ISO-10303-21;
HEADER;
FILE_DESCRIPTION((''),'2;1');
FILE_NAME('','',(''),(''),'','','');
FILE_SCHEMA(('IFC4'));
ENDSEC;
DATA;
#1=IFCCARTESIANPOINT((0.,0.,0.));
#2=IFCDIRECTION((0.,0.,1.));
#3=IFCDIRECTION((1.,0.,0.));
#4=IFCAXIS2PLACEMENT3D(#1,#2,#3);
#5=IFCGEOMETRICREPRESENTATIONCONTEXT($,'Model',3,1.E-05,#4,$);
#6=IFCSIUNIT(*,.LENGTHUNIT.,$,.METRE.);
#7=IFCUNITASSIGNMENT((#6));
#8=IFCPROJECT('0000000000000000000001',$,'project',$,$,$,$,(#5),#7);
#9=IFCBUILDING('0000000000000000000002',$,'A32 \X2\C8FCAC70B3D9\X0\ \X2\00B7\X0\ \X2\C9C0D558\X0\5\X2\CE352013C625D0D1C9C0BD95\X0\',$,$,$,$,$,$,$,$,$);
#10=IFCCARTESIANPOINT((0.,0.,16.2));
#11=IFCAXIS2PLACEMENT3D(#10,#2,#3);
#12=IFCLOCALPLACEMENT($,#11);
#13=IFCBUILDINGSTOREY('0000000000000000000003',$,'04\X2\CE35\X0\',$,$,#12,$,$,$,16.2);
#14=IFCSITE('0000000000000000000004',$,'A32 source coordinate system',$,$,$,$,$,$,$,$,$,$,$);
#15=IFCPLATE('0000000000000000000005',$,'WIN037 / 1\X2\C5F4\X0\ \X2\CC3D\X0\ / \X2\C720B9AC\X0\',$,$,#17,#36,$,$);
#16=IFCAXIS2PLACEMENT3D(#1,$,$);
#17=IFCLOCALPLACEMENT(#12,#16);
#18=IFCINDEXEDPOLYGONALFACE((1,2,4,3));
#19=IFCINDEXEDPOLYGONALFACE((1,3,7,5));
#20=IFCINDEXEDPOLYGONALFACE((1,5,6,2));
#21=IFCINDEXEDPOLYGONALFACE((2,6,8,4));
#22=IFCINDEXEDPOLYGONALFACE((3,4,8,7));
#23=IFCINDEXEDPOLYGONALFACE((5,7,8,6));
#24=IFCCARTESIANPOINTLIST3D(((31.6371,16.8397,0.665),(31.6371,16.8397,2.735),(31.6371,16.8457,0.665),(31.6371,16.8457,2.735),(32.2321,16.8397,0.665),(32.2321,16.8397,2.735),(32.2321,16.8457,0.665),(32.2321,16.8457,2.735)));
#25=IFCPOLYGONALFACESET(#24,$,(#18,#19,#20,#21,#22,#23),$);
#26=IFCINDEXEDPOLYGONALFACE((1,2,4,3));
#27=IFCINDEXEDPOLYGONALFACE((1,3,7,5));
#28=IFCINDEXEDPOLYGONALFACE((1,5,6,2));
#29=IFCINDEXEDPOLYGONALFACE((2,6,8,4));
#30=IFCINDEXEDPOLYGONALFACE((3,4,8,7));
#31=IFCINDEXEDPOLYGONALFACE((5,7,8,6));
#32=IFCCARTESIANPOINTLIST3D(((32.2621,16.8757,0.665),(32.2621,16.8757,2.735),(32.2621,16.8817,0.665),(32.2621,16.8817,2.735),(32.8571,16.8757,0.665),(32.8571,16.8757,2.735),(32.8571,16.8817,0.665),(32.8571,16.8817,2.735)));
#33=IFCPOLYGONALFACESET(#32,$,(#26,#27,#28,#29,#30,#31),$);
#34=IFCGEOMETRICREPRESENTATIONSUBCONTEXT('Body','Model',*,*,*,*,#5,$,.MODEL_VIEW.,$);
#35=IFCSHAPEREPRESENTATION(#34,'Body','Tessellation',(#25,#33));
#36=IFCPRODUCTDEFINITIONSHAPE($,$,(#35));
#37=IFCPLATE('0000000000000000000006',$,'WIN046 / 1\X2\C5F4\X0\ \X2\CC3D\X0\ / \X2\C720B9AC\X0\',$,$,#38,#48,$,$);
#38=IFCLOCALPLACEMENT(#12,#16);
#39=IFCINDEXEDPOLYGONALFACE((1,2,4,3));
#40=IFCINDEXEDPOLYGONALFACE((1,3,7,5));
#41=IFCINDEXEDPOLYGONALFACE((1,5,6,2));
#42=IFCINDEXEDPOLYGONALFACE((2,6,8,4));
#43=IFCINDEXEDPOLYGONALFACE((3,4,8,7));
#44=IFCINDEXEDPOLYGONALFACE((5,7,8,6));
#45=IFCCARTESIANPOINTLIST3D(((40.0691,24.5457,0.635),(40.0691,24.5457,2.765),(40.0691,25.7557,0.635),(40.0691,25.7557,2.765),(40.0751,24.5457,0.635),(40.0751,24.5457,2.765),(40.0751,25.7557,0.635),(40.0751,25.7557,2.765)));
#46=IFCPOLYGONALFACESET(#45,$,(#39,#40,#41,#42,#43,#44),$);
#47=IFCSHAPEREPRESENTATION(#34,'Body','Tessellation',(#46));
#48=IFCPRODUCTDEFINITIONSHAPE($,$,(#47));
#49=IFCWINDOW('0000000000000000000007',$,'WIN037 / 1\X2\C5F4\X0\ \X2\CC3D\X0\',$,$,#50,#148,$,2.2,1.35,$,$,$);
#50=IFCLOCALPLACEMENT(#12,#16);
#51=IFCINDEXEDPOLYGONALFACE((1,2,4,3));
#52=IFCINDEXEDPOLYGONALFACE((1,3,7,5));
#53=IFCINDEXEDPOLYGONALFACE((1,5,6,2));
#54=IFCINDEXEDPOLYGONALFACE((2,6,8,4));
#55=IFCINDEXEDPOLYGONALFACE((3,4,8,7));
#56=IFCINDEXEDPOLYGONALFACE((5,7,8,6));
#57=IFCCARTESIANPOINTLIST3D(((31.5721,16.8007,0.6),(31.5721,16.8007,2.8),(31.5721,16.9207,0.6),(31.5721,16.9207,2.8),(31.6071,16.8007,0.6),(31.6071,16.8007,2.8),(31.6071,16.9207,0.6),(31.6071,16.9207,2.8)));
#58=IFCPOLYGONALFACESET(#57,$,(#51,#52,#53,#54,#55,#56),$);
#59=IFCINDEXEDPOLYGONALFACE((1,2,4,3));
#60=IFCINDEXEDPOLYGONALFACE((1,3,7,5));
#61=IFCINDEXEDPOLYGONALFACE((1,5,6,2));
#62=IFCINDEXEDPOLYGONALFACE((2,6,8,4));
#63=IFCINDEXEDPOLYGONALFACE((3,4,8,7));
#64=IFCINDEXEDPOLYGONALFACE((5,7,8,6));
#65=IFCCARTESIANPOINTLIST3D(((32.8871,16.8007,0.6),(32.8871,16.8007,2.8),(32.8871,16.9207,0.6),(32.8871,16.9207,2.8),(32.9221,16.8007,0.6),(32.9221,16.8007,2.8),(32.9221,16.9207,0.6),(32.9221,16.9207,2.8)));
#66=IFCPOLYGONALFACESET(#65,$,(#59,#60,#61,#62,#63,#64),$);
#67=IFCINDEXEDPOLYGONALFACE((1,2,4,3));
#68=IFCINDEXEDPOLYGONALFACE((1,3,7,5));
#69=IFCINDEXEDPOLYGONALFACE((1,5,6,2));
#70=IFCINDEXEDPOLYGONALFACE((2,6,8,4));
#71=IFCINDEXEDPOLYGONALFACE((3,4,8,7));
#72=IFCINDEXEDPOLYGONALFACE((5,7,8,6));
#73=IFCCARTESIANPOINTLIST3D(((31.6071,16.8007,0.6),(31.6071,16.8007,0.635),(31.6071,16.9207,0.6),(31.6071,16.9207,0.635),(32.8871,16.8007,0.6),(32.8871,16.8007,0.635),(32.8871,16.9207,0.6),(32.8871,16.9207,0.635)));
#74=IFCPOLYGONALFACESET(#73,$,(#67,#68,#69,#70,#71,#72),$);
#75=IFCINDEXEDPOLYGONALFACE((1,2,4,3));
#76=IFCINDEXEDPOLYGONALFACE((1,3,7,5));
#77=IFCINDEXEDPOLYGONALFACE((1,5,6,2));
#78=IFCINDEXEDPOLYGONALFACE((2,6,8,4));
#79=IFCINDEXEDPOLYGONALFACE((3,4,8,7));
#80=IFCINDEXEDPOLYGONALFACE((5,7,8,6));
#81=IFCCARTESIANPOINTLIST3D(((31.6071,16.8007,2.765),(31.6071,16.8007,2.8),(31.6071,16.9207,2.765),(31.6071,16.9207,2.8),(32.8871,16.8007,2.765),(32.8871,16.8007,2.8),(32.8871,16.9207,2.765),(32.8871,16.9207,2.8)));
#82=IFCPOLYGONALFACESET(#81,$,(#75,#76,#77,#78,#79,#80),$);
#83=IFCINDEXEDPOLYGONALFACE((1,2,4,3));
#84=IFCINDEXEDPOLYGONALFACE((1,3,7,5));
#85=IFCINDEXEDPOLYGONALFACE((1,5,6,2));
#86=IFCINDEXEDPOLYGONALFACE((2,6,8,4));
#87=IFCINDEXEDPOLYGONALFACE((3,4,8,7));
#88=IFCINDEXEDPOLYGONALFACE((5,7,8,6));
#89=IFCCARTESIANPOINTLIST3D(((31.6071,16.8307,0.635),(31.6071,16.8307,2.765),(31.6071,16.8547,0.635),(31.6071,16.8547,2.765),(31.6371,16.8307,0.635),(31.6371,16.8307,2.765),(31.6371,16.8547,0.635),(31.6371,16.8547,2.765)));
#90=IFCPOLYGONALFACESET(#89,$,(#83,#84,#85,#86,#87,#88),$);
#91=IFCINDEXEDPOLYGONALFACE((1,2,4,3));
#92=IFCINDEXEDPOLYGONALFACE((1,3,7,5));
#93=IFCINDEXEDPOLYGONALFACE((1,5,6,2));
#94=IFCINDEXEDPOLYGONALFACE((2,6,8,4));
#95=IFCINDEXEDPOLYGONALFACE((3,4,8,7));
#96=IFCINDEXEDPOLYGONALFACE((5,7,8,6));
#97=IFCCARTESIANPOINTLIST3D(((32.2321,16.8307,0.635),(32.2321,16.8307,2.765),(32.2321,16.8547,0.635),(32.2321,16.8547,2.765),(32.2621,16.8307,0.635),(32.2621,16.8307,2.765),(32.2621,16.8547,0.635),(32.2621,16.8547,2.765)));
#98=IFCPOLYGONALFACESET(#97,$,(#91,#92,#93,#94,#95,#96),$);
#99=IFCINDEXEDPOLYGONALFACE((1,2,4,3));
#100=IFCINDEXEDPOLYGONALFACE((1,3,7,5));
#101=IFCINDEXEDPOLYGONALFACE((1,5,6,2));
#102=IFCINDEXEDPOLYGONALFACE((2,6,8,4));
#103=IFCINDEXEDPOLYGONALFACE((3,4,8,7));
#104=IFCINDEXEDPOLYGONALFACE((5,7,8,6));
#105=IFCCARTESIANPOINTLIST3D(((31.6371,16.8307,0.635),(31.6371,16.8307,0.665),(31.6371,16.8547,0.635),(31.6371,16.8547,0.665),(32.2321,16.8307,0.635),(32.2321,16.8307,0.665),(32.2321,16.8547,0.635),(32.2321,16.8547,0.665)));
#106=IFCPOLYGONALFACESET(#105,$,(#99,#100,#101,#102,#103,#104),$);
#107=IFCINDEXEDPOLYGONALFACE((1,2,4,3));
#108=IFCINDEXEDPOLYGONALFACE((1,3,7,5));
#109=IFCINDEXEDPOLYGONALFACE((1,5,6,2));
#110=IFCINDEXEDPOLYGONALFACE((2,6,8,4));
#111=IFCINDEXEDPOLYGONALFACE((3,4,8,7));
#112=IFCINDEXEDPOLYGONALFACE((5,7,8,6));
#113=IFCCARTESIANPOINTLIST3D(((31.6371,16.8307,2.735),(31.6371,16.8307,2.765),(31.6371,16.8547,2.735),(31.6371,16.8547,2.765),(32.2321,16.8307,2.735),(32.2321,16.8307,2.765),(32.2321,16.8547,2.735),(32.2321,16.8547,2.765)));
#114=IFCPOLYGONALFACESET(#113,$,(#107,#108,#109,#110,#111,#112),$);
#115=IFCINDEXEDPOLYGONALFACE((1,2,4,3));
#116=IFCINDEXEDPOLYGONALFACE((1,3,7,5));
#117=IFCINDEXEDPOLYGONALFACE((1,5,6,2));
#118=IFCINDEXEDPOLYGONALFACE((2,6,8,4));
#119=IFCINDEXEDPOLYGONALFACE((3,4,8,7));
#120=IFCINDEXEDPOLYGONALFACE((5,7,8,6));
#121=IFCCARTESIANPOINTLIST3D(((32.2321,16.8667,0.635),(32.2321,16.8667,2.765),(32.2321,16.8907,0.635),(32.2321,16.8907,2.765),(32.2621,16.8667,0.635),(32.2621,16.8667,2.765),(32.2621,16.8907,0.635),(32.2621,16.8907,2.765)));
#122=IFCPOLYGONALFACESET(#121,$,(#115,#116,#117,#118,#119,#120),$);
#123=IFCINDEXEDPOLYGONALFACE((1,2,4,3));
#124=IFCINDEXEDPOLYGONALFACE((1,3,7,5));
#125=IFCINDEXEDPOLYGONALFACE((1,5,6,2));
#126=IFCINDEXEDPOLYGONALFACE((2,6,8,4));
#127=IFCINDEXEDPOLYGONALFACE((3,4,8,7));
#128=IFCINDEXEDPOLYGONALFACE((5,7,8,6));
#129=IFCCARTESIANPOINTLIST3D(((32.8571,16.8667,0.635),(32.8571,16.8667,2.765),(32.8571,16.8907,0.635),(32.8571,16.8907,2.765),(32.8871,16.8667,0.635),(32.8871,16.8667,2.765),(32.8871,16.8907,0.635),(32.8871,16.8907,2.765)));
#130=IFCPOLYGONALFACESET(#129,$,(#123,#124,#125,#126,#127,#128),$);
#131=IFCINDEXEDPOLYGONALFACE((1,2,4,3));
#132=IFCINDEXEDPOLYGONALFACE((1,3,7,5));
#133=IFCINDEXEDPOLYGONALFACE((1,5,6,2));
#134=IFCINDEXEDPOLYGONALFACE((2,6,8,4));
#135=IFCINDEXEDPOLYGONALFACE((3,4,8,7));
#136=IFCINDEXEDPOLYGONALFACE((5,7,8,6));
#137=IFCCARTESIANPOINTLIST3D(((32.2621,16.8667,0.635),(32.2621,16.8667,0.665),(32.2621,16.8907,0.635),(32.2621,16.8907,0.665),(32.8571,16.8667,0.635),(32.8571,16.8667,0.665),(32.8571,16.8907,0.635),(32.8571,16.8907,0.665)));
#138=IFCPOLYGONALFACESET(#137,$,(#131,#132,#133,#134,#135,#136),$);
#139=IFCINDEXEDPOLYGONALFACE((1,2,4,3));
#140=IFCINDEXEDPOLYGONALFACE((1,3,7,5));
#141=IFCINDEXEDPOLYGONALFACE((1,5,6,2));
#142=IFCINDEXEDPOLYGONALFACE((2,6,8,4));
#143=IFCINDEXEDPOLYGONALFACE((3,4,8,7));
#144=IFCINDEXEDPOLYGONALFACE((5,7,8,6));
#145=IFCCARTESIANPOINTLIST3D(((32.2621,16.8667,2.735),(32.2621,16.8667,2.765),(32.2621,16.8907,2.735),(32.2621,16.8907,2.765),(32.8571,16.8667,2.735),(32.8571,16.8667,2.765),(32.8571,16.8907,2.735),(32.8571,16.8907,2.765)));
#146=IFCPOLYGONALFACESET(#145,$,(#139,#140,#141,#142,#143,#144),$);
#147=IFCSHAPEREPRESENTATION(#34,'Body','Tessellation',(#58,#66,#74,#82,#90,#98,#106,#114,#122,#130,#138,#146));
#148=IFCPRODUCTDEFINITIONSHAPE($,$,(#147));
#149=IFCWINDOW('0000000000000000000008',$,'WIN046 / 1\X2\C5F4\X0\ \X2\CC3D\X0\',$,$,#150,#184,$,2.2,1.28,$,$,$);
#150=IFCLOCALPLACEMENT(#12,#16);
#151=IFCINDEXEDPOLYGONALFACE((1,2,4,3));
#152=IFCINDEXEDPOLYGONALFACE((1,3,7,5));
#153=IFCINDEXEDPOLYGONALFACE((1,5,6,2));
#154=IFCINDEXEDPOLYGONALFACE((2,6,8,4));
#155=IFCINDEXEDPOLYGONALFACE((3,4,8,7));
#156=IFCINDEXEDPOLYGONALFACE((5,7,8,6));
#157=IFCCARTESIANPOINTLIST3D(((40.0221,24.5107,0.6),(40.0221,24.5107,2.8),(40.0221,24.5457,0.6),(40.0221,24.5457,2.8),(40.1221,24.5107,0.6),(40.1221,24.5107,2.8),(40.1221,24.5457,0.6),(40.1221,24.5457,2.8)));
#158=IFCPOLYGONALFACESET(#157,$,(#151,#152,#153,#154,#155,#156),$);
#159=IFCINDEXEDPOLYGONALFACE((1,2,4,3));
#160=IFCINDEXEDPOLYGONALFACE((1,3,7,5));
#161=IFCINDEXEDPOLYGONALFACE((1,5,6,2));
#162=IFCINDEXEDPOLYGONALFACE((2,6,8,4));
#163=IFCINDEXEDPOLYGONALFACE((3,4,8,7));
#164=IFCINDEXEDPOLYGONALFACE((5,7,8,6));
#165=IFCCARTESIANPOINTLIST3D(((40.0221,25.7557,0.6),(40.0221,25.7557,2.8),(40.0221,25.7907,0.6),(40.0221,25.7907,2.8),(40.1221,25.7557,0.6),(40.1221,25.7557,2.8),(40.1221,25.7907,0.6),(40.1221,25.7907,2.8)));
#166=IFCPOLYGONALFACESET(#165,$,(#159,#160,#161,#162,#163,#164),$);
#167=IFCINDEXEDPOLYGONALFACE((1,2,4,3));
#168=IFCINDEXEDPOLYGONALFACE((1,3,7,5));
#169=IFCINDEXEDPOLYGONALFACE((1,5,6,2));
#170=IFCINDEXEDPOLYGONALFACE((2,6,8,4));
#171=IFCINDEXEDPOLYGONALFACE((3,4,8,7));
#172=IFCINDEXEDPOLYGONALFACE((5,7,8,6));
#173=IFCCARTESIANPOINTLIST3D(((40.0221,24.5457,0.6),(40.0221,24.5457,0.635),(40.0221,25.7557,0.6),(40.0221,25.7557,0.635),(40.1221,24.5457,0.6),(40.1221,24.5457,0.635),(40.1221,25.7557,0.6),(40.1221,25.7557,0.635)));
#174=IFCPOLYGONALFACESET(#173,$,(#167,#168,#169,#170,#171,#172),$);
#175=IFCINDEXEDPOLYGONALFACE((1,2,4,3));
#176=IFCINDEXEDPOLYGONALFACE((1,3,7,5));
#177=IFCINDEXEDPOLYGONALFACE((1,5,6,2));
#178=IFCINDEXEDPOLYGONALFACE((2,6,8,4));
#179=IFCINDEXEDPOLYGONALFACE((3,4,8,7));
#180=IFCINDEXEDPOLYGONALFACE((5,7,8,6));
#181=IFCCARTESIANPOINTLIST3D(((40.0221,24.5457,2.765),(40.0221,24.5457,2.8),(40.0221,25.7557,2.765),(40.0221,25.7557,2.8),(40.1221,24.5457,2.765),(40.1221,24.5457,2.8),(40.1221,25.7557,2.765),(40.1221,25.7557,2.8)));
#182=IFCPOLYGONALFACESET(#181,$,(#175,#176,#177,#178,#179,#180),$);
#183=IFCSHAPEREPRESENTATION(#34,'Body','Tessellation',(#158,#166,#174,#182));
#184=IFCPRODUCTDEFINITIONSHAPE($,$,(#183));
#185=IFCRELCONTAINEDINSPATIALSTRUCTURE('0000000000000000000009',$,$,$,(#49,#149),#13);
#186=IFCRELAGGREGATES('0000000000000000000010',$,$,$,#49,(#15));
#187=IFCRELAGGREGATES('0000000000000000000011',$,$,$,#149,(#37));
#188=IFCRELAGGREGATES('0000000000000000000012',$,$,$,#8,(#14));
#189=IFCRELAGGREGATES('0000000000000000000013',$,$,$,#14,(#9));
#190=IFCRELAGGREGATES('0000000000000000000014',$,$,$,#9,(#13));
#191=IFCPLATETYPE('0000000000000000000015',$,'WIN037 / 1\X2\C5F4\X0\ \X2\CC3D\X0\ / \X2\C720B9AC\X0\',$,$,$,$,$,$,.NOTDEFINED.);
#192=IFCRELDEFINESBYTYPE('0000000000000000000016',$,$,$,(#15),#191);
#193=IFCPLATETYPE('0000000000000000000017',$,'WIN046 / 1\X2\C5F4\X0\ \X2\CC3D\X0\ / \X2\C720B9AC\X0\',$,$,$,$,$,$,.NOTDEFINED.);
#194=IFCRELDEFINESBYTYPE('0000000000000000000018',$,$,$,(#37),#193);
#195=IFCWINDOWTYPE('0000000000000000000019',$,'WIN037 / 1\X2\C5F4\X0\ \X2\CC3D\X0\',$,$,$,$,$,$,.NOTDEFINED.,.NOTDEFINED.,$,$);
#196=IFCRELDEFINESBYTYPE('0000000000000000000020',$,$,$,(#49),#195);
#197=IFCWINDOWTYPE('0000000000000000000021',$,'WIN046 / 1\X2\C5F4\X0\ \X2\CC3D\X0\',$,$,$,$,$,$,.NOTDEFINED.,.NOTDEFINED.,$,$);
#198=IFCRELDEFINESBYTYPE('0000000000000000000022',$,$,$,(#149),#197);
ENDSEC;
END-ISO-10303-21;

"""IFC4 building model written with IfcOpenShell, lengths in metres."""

from ifc_helpers import new_model, si_unit, frame, origin, origin_with_axes, place, context, subcontext, project, spatial, polyline, outline, extrude, source, transform, mapped, type_object, type_shapes, element, aggregate, save


model = new_model("IFC4")

# Units and contexts
model_context = context("Model", 3, precision=1e-05, world=origin_with_axes())
body_context = subcontext(model_context, "Body", "Model", "MODEL_VIEW")
ifc_project = project(units=[si_unit("LENGTHUNIT", "METRE")], contexts=[model_context])

# Plates
storey_placement = place(None, frame((0.0, 0.0, 16.2), z_axis=(0.0, 0.0, 1.0), x_axis=(1.0, 0.0, 0.0)))
plate_type_1 = type_object("IfcPlateType", Name="WIN037 / 1열 창 / 유리", PredefinedType="NOTDEFINED")
shared_shape_1 = source(origin(), body_context, "Body", "SweptSolid", [
    extrude(outline(polyline([(31.6371, 16.8397), (31.6371, 16.8457), (32.2321, 16.8457), (32.2321, 16.8397), (31.6371, 16.8397)])), frame((0.0, 0.0, 0.665)), (0.0, 0.0, 1.0), 2.07),
    extrude(outline(polyline([(32.2621, 16.8757), (32.2621, 16.8817), (32.8571, 16.8817), (32.8571, 16.8757), (32.2621, 16.8757)])), frame((0.0, 0.0, 0.665)), (0.0, 0.0, 1.0), 2.07),
])
type_shapes(plate_type_1, [shared_shape_1])
window_1_placement = place(storey_placement, origin_with_axes())
plate_1_placement = place(window_1_placement, origin_with_axes())
plate_1 = element("IfcPlate", 1, at=plate_1_placement, type_object=plate_type_1, Name="WIN037 / 1열 창 / 유리", context=body_context, shape_type="MappedRepresentation", body=[
    mapped(shared_shape_1, transform((0.0, 0.0, 0.0), scale=1.0)),
])
plate_type_2 = type_object("IfcPlateType", Name="WIN046 / 1열 창 / 유리", PredefinedType="NOTDEFINED")
shared_shape_2 = source(origin(), body_context, "Body", "SweptSolid", [
    extrude(outline(polyline([(40.0691, 24.5457), (40.0691, 25.7557), (40.0751, 25.7557), (40.0751, 24.5457), (40.0691, 24.5457)])), frame((0.0, 0.0, 0.635)), (0.0, 0.0, 1.0), 2.13),
])
type_shapes(plate_type_2, [shared_shape_2])
window_2_placement = place(storey_placement, origin_with_axes())
plate_2_placement = place(window_2_placement, origin_with_axes())
plate_2 = element("IfcPlate", 2, at=plate_2_placement, type_object=plate_type_2, Name="WIN046 / 1열 창 / 유리", context=body_context, shape_type="MappedRepresentation", body=[
    mapped(shared_shape_2, transform((0.0, 0.0, 0.0), scale=1.0)),
])

# Site, building, storey
site = spatial("IfcSite", under=ifc_project, Name="A32 source coordinate system")
building = spatial("IfcBuilding", under=site, Name="A32 주거동 · 지하5층–옥탑지붕")
storey = spatial("IfcBuildingStorey", under=building, at=storey_placement, Name="04층", Elevation=16.2)

# Windows
window_type_1 = type_object("IfcWindowType", Name="WIN037 / 1열 창", PartitioningType="NOTDEFINED", PredefinedType="NOTDEFINED")
shared_shape_3 = source(origin(), body_context, "Body", "SweptSolid", [
    extrude(outline(polyline([(31.5721, 16.8007), (31.5721, 16.9207), (31.6071, 16.9207), (31.6071, 16.8007), (31.5721, 16.8007)])), frame((0.0, 0.0, 0.6)), (0.0, 0.0, 1.0), 2.2),
    extrude(outline(polyline([(32.8871, 16.8007), (32.8871, 16.9207), (32.9221, 16.9207), (32.9221, 16.8007), (32.8871, 16.8007)])), frame((0.0, 0.0, 0.6)), (0.0, 0.0, 1.0), 2.2),
    extrude(outline(polyline([(31.6071, 16.8007), (31.6071, 16.9207), (32.8871, 16.9207), (32.8871, 16.8007), (31.6071, 16.8007)])), frame((0.0, 0.0, 0.6)), (0.0, 0.0, 1.0), 0.035),
    extrude(outline(polyline([(31.6071, 16.8007), (31.6071, 16.9207), (32.8871, 16.9207), (32.8871, 16.8007), (31.6071, 16.8007)])), frame((0.0, 0.0, 2.765)), (0.0, 0.0, 1.0), 0.035),
    extrude(outline(polyline([(31.6071, 16.8307), (31.6071, 16.8547), (31.6371, 16.8547), (31.6371, 16.8307), (31.6071, 16.8307)])), frame((0.0, 0.0, 0.635)), (0.0, 0.0, 1.0), 2.13),
    extrude(outline(polyline([(32.2321, 16.8307), (32.2321, 16.8547), (32.2621, 16.8547), (32.2621, 16.8307), (32.2321, 16.8307)])), frame((0.0, 0.0, 0.635)), (0.0, 0.0, 1.0), 2.13),
    extrude(outline(polyline([(31.6371, 16.8307), (31.6371, 16.8547), (32.2321, 16.8547), (32.2321, 16.8307), (31.6371, 16.8307)])), frame((0.0, 0.0, 0.635)), (0.0, 0.0, 1.0), 0.03),
    extrude(outline(polyline([(31.6371, 16.8307), (31.6371, 16.8547), (32.2321, 16.8547), (32.2321, 16.8307), (31.6371, 16.8307)])), frame((0.0, 0.0, 2.735)), (0.0, 0.0, 1.0), 0.03),
    extrude(outline(polyline([(32.2321, 16.8667), (32.2321, 16.8907), (32.2621, 16.8907), (32.2621, 16.8667), (32.2321, 16.8667)])), frame((0.0, 0.0, 0.635)), (0.0, 0.0, 1.0), 2.13),
    extrude(outline(polyline([(32.8571, 16.8667), (32.8571, 16.8907), (32.8871, 16.8907), (32.8871, 16.8667), (32.8571, 16.8667)])), frame((0.0, 0.0, 0.635)), (0.0, 0.0, 1.0), 2.13),
    extrude(outline(polyline([(32.2621, 16.8667), (32.2621, 16.8907), (32.8571, 16.8907), (32.8571, 16.8667), (32.2621, 16.8667)])), frame((0.0, 0.0, 0.635)), (0.0, 0.0, 1.0), 0.03),
    extrude(outline(polyline([(32.2621, 16.8667), (32.2621, 16.8907), (32.8571, 16.8907), (32.8571, 16.8667), (32.2621, 16.8667)])), frame((0.0, 0.0, 2.735)), (0.0, 0.0, 1.0), 0.03),
])
type_shapes(window_type_1, [shared_shape_3])
window_1 = element("IfcWindow", 3, at=window_1_placement, inside=storey, type_object=window_type_1, Name="WIN037 / 1열 창", OverallHeight=2.2, OverallWidth=1.35, context=body_context, shape_type="MappedRepresentation", body=[
    mapped(shared_shape_3, transform((0.0, 0.0, 0.0), scale=1.0)),
])
aggregate(window_1, [plate_1])
window_type_2 = type_object("IfcWindowType", Name="WIN046 / 1열 창", PartitioningType="NOTDEFINED", PredefinedType="NOTDEFINED")
shared_shape_4 = source(origin(), body_context, "Body", "SweptSolid", [
    extrude(outline(polyline([(40.0221, 24.5107), (40.0221, 24.5457), (40.1221, 24.5457), (40.1221, 24.5107), (40.0221, 24.5107)])), frame((0.0, 0.0, 0.6)), (0.0, 0.0, 1.0), 2.2),
    extrude(outline(polyline([(40.0221, 25.7557), (40.0221, 25.7907), (40.1221, 25.7907), (40.1221, 25.7557), (40.0221, 25.7557)])), frame((0.0, 0.0, 0.6)), (0.0, 0.0, 1.0), 2.2),
    extrude(outline(polyline([(40.0221, 24.5457), (40.0221, 25.7557), (40.1221, 25.7557), (40.1221, 24.5457), (40.0221, 24.5457)])), frame((0.0, 0.0, 0.6)), (0.0, 0.0, 1.0), 0.035),
    extrude(outline(polyline([(40.0221, 24.5457), (40.0221, 25.7557), (40.1221, 25.7557), (40.1221, 24.5457), (40.0221, 24.5457)])), frame((0.0, 0.0, 2.765)), (0.0, 0.0, 1.0), 0.035),
])
type_shapes(window_type_2, [shared_shape_4])
window_2 = element("IfcWindow", 4, at=window_2_placement, inside=storey, type_object=window_type_2, Name="WIN046 / 1열 창", OverallHeight=2.2, OverallWidth=1.28, context=body_context, shape_type="MappedRepresentation", body=[
    mapped(shared_shape_4, transform((0.0, 0.0, 0.0), scale=1.0)),
])
aggregate(window_2, [plate_2])

save(model, "model.ifc")
